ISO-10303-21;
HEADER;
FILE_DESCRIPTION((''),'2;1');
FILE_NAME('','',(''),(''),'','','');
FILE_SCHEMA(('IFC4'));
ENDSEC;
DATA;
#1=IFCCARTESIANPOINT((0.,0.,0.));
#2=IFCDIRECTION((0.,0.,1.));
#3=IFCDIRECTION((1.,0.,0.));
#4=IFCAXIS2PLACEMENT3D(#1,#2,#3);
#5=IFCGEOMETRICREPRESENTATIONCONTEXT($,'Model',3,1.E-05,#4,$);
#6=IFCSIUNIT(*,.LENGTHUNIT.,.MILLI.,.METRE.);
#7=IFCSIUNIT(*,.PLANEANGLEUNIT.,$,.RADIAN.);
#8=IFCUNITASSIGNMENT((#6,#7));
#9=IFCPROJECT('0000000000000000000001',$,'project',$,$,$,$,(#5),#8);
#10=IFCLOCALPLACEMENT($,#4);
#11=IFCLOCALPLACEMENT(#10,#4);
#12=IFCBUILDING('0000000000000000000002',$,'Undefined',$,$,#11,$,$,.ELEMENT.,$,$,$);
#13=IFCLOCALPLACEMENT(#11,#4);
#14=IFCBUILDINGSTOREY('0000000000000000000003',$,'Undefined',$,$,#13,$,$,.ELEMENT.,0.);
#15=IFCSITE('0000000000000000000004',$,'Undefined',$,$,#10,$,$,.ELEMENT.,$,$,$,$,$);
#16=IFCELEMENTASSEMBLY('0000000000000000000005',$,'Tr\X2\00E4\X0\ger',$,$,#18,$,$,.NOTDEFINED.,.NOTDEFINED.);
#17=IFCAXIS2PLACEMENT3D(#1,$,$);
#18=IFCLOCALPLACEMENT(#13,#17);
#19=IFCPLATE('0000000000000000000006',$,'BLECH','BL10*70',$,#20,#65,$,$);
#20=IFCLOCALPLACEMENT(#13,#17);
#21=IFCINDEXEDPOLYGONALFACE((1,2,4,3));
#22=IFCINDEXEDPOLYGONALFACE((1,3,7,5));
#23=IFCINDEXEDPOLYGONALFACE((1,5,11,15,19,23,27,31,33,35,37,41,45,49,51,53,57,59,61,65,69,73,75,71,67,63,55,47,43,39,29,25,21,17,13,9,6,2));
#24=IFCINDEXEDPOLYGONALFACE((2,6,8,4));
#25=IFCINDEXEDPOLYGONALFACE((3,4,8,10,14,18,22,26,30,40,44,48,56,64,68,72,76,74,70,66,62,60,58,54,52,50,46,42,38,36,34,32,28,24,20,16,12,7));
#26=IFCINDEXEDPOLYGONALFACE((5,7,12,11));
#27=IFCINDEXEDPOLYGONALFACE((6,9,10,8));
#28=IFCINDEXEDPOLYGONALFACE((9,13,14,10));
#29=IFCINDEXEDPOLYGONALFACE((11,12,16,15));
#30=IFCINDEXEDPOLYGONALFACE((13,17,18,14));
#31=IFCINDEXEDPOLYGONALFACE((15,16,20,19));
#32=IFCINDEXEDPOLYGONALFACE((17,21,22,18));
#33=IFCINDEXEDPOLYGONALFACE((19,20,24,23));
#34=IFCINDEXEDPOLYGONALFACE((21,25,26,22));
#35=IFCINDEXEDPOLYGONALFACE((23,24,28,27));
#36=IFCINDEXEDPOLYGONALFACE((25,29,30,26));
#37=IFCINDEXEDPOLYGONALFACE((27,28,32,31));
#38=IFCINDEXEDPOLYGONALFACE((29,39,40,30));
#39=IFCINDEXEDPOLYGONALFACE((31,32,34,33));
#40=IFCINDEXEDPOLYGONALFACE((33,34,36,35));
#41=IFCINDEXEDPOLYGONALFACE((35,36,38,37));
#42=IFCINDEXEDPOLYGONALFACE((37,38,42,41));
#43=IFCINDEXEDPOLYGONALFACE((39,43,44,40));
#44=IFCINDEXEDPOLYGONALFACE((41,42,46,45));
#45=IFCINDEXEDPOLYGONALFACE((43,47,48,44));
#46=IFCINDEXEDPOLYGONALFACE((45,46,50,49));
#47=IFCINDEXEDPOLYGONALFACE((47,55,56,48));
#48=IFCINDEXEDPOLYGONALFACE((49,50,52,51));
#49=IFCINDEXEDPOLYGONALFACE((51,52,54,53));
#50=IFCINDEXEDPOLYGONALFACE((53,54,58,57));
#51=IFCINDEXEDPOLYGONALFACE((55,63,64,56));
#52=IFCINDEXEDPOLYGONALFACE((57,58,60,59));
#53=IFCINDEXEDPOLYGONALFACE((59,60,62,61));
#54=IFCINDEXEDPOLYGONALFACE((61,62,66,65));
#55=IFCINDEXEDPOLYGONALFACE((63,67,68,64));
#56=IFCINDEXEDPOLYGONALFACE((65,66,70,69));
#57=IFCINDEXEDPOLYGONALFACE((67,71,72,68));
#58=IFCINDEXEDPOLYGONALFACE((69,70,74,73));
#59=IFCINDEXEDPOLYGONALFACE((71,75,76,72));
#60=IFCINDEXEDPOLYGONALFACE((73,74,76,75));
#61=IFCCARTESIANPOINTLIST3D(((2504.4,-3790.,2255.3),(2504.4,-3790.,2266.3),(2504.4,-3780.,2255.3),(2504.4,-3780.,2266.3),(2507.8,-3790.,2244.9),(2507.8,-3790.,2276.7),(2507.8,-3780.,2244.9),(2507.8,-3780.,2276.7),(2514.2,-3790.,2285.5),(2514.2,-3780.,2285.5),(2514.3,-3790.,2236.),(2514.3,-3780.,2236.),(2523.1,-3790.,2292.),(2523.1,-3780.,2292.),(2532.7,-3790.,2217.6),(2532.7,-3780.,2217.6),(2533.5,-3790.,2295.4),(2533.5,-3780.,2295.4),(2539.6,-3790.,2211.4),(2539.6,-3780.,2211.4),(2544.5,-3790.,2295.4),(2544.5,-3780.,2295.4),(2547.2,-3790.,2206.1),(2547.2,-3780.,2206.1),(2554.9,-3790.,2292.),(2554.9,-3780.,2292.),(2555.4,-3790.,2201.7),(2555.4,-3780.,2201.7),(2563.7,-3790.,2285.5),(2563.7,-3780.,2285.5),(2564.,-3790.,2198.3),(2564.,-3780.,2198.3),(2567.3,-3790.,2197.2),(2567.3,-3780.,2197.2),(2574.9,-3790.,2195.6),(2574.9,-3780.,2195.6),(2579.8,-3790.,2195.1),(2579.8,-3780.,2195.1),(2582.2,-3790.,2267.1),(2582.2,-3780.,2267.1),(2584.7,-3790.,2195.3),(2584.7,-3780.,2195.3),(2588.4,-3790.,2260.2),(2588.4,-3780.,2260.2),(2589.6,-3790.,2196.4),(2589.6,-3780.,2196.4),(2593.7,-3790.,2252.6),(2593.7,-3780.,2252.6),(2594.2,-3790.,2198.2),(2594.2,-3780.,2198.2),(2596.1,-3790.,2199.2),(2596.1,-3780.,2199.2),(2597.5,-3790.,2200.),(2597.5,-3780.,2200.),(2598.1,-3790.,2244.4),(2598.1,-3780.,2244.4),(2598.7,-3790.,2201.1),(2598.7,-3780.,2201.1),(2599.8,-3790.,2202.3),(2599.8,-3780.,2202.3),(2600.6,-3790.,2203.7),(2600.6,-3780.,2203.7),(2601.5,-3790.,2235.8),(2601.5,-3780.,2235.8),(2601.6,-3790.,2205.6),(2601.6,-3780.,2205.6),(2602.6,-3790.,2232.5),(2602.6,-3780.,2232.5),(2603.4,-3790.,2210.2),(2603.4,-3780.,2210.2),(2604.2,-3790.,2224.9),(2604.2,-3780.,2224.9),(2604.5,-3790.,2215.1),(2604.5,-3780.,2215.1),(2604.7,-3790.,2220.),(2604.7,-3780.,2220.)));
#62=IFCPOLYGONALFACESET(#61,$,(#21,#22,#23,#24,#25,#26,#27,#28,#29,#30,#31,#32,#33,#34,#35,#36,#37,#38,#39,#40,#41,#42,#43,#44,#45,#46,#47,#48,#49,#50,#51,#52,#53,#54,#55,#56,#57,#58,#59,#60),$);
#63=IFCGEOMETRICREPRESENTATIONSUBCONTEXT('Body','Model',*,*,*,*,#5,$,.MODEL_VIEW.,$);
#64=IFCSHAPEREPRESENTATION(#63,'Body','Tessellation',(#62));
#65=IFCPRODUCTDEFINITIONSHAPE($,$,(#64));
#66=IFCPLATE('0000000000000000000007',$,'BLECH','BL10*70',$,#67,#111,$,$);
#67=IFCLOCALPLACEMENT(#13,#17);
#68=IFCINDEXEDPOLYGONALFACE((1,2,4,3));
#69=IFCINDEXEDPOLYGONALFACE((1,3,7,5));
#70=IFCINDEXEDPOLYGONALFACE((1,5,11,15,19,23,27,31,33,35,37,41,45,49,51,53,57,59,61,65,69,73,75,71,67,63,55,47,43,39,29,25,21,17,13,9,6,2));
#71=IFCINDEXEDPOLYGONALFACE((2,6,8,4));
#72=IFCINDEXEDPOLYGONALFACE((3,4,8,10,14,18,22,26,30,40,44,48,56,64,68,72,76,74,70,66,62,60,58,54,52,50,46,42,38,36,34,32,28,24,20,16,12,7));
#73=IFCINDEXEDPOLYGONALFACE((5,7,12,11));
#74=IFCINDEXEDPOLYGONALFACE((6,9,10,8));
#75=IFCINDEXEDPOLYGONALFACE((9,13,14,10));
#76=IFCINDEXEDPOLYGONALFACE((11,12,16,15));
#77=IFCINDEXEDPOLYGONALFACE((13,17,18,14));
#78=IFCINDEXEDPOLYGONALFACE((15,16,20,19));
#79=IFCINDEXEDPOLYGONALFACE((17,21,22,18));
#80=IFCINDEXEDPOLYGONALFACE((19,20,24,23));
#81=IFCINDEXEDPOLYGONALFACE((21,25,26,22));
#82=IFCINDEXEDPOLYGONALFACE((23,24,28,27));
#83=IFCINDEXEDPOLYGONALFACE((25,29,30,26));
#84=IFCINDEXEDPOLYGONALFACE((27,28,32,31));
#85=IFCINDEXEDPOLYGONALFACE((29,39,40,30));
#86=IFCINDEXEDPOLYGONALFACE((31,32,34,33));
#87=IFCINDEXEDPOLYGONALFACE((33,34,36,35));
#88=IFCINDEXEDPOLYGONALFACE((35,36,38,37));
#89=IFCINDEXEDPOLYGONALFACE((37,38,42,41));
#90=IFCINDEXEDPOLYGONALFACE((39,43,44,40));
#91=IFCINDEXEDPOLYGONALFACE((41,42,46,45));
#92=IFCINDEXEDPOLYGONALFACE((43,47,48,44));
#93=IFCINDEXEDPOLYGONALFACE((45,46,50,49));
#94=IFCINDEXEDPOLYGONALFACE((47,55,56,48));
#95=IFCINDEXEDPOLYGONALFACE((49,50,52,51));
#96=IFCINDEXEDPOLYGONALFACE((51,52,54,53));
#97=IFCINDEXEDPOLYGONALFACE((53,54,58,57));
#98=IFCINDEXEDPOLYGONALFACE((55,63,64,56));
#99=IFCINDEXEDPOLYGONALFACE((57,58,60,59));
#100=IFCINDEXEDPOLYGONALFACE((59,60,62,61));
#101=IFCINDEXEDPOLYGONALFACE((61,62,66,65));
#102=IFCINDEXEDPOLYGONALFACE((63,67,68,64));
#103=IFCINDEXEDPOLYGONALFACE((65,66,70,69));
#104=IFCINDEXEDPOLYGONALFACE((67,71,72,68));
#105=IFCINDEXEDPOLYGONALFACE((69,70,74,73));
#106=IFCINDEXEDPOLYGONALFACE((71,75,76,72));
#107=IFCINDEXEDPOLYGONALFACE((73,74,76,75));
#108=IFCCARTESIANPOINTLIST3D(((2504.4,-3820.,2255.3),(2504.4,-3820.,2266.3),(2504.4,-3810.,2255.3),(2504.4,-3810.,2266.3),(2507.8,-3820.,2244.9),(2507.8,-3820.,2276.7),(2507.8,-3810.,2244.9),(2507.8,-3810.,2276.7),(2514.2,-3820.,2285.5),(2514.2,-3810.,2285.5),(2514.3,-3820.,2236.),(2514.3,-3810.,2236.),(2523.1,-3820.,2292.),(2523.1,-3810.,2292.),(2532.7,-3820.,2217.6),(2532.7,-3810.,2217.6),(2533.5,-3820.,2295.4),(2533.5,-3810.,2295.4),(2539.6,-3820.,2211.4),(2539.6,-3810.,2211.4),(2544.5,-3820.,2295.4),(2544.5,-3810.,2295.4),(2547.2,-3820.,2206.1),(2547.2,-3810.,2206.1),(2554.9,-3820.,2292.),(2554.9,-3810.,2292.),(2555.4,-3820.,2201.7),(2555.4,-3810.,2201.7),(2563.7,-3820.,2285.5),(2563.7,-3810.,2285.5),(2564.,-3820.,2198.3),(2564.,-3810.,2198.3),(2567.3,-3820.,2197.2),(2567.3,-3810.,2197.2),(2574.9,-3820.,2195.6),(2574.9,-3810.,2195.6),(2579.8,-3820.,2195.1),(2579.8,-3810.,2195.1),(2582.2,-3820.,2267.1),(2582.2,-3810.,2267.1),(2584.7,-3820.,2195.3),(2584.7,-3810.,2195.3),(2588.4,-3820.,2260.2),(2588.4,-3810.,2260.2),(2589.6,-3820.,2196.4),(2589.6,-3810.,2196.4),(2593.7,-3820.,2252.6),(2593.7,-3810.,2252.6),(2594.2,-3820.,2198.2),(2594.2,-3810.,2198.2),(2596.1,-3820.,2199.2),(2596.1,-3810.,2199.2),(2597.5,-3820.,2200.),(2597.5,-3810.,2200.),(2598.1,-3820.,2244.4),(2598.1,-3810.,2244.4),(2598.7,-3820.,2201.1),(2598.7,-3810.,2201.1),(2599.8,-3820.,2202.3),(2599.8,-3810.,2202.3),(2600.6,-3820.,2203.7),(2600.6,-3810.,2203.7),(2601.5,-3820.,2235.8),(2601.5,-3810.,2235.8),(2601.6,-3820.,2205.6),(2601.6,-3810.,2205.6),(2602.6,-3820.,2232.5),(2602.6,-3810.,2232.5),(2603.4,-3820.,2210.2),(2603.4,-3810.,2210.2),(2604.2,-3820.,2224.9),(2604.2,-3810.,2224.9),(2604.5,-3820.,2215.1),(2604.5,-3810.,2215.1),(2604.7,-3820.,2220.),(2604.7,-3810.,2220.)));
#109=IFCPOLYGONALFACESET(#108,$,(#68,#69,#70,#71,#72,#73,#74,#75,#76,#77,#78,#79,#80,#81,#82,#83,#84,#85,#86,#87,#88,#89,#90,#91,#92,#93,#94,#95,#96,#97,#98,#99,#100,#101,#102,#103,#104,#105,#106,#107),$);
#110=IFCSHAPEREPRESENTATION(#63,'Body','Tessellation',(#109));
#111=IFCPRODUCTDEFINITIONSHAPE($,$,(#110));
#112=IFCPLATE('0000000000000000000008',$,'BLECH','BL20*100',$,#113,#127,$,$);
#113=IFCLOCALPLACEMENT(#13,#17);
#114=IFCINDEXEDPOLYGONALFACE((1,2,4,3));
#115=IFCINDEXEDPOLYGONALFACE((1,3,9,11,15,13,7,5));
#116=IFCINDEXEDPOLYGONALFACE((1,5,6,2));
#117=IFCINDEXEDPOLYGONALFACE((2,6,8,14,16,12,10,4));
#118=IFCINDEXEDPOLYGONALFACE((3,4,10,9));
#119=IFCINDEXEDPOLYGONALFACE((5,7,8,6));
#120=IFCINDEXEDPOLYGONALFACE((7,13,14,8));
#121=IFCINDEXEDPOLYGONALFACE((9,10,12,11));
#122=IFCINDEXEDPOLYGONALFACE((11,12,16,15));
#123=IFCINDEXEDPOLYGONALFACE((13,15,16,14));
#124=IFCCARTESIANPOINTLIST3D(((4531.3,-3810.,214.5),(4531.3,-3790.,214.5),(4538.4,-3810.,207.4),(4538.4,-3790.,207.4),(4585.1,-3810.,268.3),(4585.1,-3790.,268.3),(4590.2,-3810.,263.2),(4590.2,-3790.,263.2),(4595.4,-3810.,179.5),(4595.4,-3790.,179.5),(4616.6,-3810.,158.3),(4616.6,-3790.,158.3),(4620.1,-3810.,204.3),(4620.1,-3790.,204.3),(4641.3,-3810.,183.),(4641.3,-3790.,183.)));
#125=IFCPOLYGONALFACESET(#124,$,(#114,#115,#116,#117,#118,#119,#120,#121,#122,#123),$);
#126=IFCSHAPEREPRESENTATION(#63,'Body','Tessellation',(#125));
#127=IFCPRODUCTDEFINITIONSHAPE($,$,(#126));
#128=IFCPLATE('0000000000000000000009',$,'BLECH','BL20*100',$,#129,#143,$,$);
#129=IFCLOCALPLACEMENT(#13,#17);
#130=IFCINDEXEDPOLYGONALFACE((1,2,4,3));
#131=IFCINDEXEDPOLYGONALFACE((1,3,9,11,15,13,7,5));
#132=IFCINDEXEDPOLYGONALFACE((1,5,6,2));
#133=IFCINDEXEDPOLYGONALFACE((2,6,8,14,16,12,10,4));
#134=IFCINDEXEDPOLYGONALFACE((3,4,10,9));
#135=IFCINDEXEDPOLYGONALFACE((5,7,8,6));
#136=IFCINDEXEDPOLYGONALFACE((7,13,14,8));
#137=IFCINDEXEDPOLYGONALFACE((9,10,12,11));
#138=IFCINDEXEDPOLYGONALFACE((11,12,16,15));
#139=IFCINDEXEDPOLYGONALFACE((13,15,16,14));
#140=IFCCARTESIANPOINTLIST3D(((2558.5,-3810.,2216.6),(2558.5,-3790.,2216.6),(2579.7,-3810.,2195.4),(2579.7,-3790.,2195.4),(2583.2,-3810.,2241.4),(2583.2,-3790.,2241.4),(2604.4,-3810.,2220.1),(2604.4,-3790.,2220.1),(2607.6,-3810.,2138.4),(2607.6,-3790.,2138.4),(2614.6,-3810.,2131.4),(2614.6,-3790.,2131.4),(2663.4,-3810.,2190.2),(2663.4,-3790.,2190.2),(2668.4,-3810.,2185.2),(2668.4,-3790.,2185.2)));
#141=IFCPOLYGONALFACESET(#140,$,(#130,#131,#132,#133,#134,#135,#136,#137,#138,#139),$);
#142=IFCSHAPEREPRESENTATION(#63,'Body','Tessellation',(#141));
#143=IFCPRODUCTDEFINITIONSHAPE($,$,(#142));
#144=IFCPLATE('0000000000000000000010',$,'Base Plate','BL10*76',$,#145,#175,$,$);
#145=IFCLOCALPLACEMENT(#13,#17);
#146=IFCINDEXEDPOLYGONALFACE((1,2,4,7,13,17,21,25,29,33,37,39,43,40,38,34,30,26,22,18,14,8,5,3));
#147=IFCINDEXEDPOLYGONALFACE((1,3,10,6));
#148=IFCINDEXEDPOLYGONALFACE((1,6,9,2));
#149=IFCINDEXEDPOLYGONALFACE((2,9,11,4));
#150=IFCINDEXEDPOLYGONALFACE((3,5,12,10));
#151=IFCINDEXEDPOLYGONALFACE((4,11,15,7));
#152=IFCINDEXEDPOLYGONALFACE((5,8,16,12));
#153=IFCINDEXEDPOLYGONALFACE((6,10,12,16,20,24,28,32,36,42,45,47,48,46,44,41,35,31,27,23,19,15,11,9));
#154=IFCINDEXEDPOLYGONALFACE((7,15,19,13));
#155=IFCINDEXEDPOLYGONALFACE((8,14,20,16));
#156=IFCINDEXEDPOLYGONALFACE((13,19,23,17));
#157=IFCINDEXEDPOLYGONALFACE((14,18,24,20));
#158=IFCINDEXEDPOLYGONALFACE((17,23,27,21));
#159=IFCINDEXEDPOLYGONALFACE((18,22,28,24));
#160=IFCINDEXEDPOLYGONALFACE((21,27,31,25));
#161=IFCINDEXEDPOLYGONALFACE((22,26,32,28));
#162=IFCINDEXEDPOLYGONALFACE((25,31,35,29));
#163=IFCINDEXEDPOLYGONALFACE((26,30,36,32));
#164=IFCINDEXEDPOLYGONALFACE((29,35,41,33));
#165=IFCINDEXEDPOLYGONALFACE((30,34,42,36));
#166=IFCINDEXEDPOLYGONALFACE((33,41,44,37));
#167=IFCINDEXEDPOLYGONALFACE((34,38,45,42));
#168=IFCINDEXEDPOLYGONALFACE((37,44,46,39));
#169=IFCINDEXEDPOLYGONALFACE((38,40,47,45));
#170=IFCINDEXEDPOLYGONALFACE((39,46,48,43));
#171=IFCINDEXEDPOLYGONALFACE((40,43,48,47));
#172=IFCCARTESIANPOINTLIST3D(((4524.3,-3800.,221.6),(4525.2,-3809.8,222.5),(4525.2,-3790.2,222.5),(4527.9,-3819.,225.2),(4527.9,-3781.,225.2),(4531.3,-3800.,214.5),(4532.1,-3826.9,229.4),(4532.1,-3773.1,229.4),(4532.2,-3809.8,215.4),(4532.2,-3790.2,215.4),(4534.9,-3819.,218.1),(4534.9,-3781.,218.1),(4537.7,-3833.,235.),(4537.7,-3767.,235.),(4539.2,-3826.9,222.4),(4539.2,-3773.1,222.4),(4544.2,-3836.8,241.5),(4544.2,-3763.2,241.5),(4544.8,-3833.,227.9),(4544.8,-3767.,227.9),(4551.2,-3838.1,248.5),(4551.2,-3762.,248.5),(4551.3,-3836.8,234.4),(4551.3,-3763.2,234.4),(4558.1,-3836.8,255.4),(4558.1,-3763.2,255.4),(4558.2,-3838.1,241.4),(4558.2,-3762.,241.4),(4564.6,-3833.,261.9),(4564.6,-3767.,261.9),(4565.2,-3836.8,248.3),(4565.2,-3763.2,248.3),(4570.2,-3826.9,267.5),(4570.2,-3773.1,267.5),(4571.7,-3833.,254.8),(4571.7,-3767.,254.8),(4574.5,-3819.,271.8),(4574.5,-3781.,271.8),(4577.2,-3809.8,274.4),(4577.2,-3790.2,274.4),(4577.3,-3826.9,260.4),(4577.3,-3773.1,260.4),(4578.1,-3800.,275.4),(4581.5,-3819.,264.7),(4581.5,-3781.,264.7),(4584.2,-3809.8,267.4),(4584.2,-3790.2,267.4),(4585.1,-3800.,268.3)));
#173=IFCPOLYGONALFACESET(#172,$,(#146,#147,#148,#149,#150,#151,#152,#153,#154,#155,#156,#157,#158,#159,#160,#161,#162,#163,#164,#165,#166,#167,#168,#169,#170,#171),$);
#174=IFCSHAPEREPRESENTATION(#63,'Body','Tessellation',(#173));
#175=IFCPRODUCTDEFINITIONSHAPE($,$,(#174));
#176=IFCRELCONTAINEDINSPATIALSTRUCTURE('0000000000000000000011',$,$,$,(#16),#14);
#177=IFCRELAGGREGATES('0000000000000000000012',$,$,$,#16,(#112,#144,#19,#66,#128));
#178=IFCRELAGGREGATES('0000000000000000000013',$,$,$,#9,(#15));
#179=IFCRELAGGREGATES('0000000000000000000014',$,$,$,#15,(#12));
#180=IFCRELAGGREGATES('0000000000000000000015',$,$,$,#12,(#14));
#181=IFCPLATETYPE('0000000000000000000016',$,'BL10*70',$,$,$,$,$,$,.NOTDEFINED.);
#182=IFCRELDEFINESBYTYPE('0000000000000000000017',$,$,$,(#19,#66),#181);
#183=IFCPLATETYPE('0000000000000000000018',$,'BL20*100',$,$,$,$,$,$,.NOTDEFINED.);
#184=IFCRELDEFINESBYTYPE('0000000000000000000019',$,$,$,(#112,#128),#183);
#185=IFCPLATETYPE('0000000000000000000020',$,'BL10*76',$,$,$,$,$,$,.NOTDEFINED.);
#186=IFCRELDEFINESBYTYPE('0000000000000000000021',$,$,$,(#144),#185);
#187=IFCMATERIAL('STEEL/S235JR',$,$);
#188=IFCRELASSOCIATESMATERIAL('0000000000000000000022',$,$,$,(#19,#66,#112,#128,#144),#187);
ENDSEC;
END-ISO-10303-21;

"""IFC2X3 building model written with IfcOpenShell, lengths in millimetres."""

from ifc_helpers import new_model, si_unit, frame, frame_2d, origin_with_axes, place, context, subcontext, project, spatial, polyline, circle_curve, parameter, trimmed, segment, composite_curve, outline, extrude, material, type_object, element, aggregate, save


model = new_model("IFC2X3")

# Units and contexts
model_context = context("Model", 3, precision=1e-05, world=origin_with_axes())
body_context = subcontext(model_context, "Body", "Model", "MODEL_VIEW")
ifc_project = project(units=[si_unit("LENGTHUNIT", "METRE", prefix="MILLI"), si_unit("PLANEANGLEUNIT", "RADIAN")], contexts=[model_context])

# Site, building, storey
site_placement = place(None, origin_with_axes())
site = spatial("IfcSite", under=ifc_project, at=site_placement, Name="Undefined", CompositionType="ELEMENT")
building_placement = place(site_placement, origin_with_axes())
building = spatial("IfcBuilding", under=site, at=building_placement, Name="Undefined", CompositionType="ELEMENT")
storey_placement = place(building_placement, origin_with_axes())
storey = spatial("IfcBuildingStorey", under=building, at=storey_placement, Name="Undefined", CompositionType="ELEMENT", Elevation=0.0)

# Shared definitions
ifc_material_1 = material(Name="STEEL/S235JR")

# Element assembly
assembly_1_placement = place(storey_placement, origin_with_axes())
assembly_1 = element("IfcElementAssembly", 1, at=assembly_1_placement, inside=storey, Name="Träger", AssemblyPlace="NOTDEFINED", PredefinedType="NOTDEFINED")

# Plates
plate_type_1 = type_object("IfcPlateType", Name="BL10*70", PredefinedType="NOTDEFINED")
plate_1_placement = place(assembly_1_placement, frame((2546.1, -3785.0, 2204.2), z_axis=(0.0, -1.0, 0.0), x_axis=(0.948699, 0.0, -0.316182)))
plate_1 = element("IfcPlate", 2, at=plate_1_placement, type_object=plate_type_1, material=ifc_material_1, Name="BLECH", Description="BL10*70", context=body_context, shape_type="SweptSolid", body=[
    extrude(outline(polyline([(-16.9, 8.4), (-8.4, 4.8), (0.5, 2.1), (9.6, 0.5), (18.9, 0.0), (22.4, 0.0), (30.0, 1.0), (34.9, 2.0), (39.5, 3.8), (43.7, 6.3), (47.5, 9.5), (49.1, 11.1), (50.1, 12.3), (50.9, 13.7), (51.5, 15.1), (51.9, 16.7), (52.2, 18.9), (52.5, 23.8), (52.0, 28.7), (50.6, 33.5), (48.6, 38.0), (44.7, 44.7), (42.6, 47.5), (36.6, 54.6), (29.9, 60.9), (22.4, 66.4), (14.4, 71.0), (-9.0, 82.7), (-19.4, 86.0), (-30.3, 86.0), (-40.7, 82.5), (-49.5, 76.0), (-55.9, 67.1), (-55.9, 67.1), (-59.2, 56.6), (-59.1, 45.7), (-55.7, 35.3), (-49.2, 26.5), (-40.3, 20.1), (-16.9, 8.4)])), frame((0.0, 0.0, -5.0), z_axis=(0.0, 0.0, 1.0), x_axis=(1.0, 0.0, 0.0)), (0.0, 0.0, 1.0), 10.0),
])
plate_2_placement = place(assembly_1_placement, frame((2546.1, -3815.0, 2204.2), z_axis=(0.0, -1.0, 0.0), x_axis=(0.948699, 0.0, -0.316182)))
plate_2 = element("IfcPlate", 3, at=plate_2_placement, type_object=plate_type_1, material=ifc_material_1, Name="BLECH", Description="BL10*70", context=body_context, shape_type="SweptSolid", body=[
    extrude(outline(polyline([(-16.9, 8.4), (-8.4, 4.8), (0.5, 2.1), (9.6, 0.5), (18.9, 0.0), (22.4, 0.0), (30.0, 1.0), (34.9, 2.0), (39.5, 3.8), (43.7, 6.3), (47.5, 9.5), (49.1, 11.1), (50.1, 12.3), (50.9, 13.7), (51.5, 15.1), (51.9, 16.7), (52.2, 18.9), (52.5, 23.8), (52.0, 28.7), (50.6, 33.5), (48.6, 38.0), (44.7, 44.7), (42.6, 47.5), (36.6, 54.6), (29.9, 60.9), (22.4, 66.4), (14.4, 71.0), (-9.0, 82.7), (-19.4, 86.0), (-30.3, 86.0), (-40.7, 82.5), (-49.5, 76.0), (-55.9, 67.1), (-55.9, 67.1), (-59.2, 56.6), (-59.1, 45.7), (-55.7, 35.3), (-49.2, 26.5), (-40.3, 20.1), (-16.9, 8.4)])), frame((0.0, 0.0, -5.0), z_axis=(0.0, 0.0, 1.0), x_axis=(1.0, 0.0, 0.0)), (0.0, 0.0, 1.0), 10.0),
])
plate_type_2 = type_object("IfcPlateType", Name="BL20*100", PredefinedType="NOTDEFINED")
plate_3_placement = place(assembly_1_placement, frame((4538.4, -3800.0, 207.4), z_axis=(0.0, 1.0, 0.0), x_axis=(-0.707003, 0.0, 0.70721)))
plate_3 = element("IfcPlate", 4, at=plate_3_placement, type_object=plate_type_2, material=ifc_material_1, Name="BLECH", Description="BL20*100", context=body_context, shape_type="SweptSolid", body=[
    extrude(outline(polyline([(0.0, 0.0), (10.0, 0.0), (10.0, 76.1), (2.9, 76.1), (-60.0, 55.5), (-90.0, 55.5), (-90.0, 20.5), (-60.0, 20.5), (0.0, 0.0)])), frame((0.0, 0.0, -10.0), z_axis=(0.0, 0.0, 1.0), x_axis=(1.0, 0.0, 0.0)), (0.0, 0.0, 1.0), 20.0),
])
plate_4_placement = place(assembly_1_placement, frame((2607.6, -3800.0, 2138.4), z_axis=(0.0, -1.0, 0.0), x_axis=(0.707141, 0.0, -0.707072)))
plate_4 = element("IfcPlate", 5, at=plate_4_placement, type_object=plate_type_2, material=ifc_material_1, Name="BLECH", Description="BL20*100", context=body_context, shape_type="SweptSolid", body=[
    extrude(outline(polyline([(0.0, 0.0), (10.0, 0.0), (10.0, 76.1), (2.9, 76.1), (-60.0, 55.5), (-90.0, 55.5), (-90.0, 20.5), (-60.0, 20.5), (0.0, 0.0)])), frame((0.0, 0.0, -10.0), z_axis=(0.0, 0.0, 1.0), x_axis=(1.0, 0.0, 0.0)), (0.0, 0.0, 1.0), 20.0),
])
plate_type_3 = type_object("IfcPlateType", Name="BL10*76", PredefinedType="NOTDEFINED")
plate_5_placement = place(assembly_1_placement, frame((4581.6, -3838.1, 271.8), z_axis=(0.707003, 0.0, -0.70721), x_axis=(-0.70721, 0.0, -0.707003)))
plate_5 = element("IfcPlate", 6, at=plate_5_placement, type_object=plate_type_3, material=ifc_material_1, Name="Base Plate", Description="BL10*76", context=body_context, shape_type="SweptSolid", body=[
    extrude(outline(composite_curve([segment(trimmed(circle_curve(frame_2d((38.0, 38.0), x_axis=(-1.0, 0.0)), 38.0), [parameter(0.0)], [parameter(1.570796)], True, "PARAMETER"), True, "CONTINUOUS"), segment(trimmed(circle_curve(frame_2d((38.0, 38.0), x_axis=(0.0, -1.0)), 38.0), [parameter(0.0)], [parameter(1.570796)], True, "PARAMETER"), True, "CONTINUOUS"), segment(trimmed(circle_curve(frame_2d((38.0, 38.0), x_axis=(1.0, 0.0)), 38.0), [parameter(0.0)], [parameter(1.570796)], True, "PARAMETER"), True, "CONTINUOUS"), segment(trimmed(circle_curve(frame_2d((38.0, 38.0), x_axis=(0.0, 1.0)), 38.0), [parameter(0.0)], [parameter(1.570796)], True, "PARAMETER"), True, "CONTINUOUS")], self_intersect=True)), frame((0.0, 0.0, -5.0), z_axis=(0.0, 0.0, 1.0), x_axis=(1.0, 0.0, 0.0)), (0.0, 0.0, 1.0), 10.0),
])
aggregate(assembly_1, [plate_3, plate_5, plate_1, plate_2, plate_4])

save(model, "model.ifc")
